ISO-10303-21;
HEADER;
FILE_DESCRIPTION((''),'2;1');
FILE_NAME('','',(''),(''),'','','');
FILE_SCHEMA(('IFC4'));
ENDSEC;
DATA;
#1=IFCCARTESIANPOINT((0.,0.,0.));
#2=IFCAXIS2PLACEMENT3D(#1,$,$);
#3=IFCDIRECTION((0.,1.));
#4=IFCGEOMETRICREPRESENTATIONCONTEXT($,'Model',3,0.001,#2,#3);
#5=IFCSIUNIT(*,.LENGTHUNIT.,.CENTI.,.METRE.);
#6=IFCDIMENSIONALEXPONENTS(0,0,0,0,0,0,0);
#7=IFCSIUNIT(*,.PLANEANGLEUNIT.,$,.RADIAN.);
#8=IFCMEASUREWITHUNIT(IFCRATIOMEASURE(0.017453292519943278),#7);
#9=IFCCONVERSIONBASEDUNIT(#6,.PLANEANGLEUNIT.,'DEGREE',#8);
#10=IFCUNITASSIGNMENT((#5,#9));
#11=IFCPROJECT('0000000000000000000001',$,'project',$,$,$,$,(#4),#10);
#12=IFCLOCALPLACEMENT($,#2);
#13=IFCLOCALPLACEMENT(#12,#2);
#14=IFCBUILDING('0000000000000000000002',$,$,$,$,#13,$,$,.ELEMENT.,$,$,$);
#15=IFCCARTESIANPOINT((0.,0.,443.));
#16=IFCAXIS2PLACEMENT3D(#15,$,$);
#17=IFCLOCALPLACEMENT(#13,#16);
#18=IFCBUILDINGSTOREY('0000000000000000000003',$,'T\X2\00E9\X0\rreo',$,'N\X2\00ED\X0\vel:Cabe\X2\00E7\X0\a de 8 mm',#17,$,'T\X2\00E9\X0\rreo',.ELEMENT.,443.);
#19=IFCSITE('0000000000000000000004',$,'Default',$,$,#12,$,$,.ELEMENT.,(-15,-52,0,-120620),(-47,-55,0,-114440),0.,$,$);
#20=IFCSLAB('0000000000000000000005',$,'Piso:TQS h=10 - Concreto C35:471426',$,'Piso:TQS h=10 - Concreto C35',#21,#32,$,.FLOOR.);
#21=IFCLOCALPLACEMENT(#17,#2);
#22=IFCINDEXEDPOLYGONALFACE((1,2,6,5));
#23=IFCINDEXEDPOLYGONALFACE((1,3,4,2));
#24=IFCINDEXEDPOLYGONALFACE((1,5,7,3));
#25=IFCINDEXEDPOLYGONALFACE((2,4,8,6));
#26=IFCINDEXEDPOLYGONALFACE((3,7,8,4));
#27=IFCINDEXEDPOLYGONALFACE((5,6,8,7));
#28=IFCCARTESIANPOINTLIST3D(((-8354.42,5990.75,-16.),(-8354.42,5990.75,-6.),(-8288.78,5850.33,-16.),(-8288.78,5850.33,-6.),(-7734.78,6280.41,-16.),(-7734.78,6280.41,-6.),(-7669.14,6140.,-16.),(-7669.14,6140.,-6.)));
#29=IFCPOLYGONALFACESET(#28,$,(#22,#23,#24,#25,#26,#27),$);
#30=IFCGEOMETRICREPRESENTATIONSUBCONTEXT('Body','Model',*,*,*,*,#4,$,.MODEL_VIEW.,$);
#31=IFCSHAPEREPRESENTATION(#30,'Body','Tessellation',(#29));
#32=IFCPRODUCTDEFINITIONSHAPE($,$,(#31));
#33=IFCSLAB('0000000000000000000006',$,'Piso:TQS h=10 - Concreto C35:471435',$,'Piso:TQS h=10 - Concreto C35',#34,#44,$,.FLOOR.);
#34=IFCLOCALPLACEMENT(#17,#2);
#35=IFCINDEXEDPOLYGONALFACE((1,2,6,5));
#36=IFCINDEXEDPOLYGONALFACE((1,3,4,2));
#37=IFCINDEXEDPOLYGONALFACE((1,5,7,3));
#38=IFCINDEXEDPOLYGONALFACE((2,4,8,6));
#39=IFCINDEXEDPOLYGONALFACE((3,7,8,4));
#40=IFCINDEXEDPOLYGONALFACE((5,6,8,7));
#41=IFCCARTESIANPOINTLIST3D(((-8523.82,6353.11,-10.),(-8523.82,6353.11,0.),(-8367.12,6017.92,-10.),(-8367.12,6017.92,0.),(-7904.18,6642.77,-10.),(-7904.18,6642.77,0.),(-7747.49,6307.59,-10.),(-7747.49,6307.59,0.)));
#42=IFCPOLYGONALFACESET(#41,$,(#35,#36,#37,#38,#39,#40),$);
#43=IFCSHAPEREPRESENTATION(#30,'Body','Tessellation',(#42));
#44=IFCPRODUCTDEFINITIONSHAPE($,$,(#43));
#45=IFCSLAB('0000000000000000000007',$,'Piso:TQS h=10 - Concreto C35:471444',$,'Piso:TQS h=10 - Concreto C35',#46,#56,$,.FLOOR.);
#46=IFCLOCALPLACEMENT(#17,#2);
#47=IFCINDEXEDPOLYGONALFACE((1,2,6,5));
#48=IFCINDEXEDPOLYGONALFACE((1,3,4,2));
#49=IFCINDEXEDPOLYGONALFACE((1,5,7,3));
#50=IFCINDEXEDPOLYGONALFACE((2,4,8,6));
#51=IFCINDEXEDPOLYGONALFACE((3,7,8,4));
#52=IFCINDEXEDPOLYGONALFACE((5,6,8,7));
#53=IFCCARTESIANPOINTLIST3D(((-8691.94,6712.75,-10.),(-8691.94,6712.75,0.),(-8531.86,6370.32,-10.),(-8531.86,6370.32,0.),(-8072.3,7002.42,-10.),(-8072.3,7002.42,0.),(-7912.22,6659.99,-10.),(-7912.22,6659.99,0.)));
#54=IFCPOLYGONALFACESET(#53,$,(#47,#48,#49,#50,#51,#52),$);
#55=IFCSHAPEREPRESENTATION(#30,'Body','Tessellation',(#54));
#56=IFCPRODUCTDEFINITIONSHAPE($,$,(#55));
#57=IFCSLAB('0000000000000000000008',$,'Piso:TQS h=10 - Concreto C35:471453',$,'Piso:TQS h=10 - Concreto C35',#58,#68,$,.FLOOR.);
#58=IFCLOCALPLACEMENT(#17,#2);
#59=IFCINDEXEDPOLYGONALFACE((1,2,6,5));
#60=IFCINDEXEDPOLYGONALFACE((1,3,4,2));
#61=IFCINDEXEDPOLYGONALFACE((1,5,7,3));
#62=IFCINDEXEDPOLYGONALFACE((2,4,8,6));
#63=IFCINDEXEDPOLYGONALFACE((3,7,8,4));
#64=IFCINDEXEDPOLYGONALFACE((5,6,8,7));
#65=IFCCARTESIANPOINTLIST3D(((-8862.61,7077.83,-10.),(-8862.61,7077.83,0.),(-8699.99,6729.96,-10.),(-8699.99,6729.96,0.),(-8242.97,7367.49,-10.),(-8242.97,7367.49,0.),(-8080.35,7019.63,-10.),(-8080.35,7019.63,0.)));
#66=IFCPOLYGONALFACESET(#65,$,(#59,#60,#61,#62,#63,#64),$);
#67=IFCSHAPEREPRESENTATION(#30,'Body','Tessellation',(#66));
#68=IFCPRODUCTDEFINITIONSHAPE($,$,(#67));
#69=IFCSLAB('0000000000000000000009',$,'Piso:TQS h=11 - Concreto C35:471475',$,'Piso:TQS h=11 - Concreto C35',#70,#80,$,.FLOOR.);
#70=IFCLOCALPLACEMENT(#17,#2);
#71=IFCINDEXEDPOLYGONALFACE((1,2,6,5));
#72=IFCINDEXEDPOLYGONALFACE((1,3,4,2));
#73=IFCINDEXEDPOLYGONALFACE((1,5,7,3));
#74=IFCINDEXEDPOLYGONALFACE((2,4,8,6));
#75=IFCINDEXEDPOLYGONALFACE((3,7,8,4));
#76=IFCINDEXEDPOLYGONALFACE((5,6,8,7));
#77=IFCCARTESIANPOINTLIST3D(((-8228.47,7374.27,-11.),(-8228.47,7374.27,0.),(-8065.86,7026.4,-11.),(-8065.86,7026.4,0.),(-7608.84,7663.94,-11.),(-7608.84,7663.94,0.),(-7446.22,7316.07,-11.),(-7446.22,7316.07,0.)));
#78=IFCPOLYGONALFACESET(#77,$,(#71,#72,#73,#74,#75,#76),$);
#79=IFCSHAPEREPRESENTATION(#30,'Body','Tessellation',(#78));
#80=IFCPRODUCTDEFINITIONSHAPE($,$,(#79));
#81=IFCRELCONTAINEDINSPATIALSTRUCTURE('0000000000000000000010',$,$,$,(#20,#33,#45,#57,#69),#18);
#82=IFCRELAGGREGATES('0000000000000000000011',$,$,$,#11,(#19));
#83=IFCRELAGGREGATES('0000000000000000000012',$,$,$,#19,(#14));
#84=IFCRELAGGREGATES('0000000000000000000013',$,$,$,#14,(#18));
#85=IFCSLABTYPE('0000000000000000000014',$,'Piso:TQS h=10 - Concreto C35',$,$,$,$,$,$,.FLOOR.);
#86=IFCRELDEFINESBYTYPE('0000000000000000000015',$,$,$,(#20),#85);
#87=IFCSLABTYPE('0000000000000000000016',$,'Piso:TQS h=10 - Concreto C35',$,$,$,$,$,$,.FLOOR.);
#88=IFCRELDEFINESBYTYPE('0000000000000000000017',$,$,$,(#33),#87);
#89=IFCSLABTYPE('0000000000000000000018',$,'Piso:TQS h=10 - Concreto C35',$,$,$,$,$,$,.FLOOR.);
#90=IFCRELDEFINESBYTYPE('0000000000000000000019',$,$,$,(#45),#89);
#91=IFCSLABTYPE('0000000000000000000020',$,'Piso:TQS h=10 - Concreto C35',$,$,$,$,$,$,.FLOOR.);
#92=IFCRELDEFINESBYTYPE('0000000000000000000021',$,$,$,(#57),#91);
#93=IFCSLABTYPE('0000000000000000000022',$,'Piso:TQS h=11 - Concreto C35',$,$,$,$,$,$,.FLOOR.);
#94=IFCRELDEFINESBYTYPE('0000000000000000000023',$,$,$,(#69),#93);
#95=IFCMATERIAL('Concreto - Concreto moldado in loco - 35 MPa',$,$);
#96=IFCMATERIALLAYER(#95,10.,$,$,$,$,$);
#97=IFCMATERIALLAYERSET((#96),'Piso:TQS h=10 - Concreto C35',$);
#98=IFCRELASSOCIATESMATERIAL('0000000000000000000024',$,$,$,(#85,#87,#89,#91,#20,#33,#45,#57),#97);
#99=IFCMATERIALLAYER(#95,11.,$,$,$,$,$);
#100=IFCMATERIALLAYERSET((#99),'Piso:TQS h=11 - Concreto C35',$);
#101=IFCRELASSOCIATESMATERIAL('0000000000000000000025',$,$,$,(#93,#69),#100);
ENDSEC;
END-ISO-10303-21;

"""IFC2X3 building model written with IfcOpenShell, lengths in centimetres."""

from ifc_helpers import new_model, entity, si_unit, converted_unit, direction, frame, frame_2d, origin, origin_2d_with_axis, place, context, subcontext, project, spatial, rectangle, extrude, material, layer, layer_set, layer_usage, type_object, element, save


model = new_model("IFC2X3")

# Units and contexts
model_context = context("Model", 3, precision=0.001, world=origin(), true_north=direction((0.0, 1.0)))
body_context = subcontext(model_context, "Body", "Model", "MODEL_VIEW")
ifc_project = project(units=[si_unit("LENGTHUNIT", "METRE", prefix="CENTI"), converted_unit("PLANEANGLEUNIT", "DEGREE", entity("IfcRatioMeasure", 0.017453292519943278), si_unit("PLANEANGLEUNIT", "RADIAN"), dimensions=[0, 0, 0, 0, 0, 0, 0])], contexts=[model_context])

# Site, building, storey
site_placement = place(None, origin())
site = spatial("IfcSite", under=ifc_project, at=site_placement, Name="Default", CompositionType="ELEMENT", RefLatitude=(-15, -52, 0, -120620), RefLongitude=(-47, -55, 0, -114440), RefElevation=0.0)
building_placement = place(site_placement, origin())
building = spatial("IfcBuilding", under=site, at=building_placement, CompositionType="ELEMENT")
storey_placement = place(building_placement, frame((0.0, 0.0, 443.0)))
storey = spatial("IfcBuildingStorey", under=building, at=storey_placement, Name="Térreo", ObjectType="Nível:Cabeça de 8 mm", LongName="Térreo", CompositionType="ELEMENT", Elevation=443.0)

# Slabs
ifc_material = material(Name="Concreto - Concreto moldado in loco - 35 MPa")
ifc_layer_1 = layer(ifc_material, 11.0)
ifc_layer_set_1 = layer_set([ifc_layer_1], Name="Piso:TQS h=11 - Concreto C35")
ifc_layer_2 = layer(ifc_material, 10.0)
ifc_layer_set_2 = layer_set([ifc_layer_2], Name="Piso:TQS h=10 - Concreto C35")
ifc_layer_usage_1 = layer_usage(ifc_layer_set_2, "AXIS3", "POSITIVE", 0.0)
slab_type_1 = type_object("IfcSlabType", Name="Piso:TQS h=10 - Concreto C35", PredefinedType="FLOOR", material=ifc_layer_set_2)
slab_1_placement = place(storey_placement, origin())
element("IfcSlab", 1, at=slab_1_placement, inside=storey, type_object=slab_type_1, material=ifc_layer_usage_1, Name="Piso:TQS h=10 - Concreto C35:471426", ObjectType="Piso:TQS h=10 - Concreto C35", PredefinedType="FLOOR", context=body_context, shape_type="SweptSolid", body=[
    extrude(rectangle(XDim=155.0, YDim=684.0, at=frame_2d((0.0, 0.0), x_axis=(1.0, 0.0))), frame((-8011.78, 6065.37, -6.0), z_axis=(0.0, 0.0, -1.0), x_axis=(0.423488, -0.905902, 0.0)), (0.0, 0.0, 1.0), 10.0),
])
ifc_layer_usage_2 = layer_usage(ifc_layer_set_2, "AXIS3", "POSITIVE", 0.0)
slab_type_2 = type_object("IfcSlabType", Name="Piso:TQS h=10 - Concreto C35", PredefinedType="FLOOR", material=ifc_layer_set_2)
slab_2_placement = place(storey_placement, origin())
element("IfcSlab", 2, at=slab_2_placement, inside=storey, type_object=slab_type_2, material=ifc_layer_usage_2, Name="Piso:TQS h=10 - Concreto C35:471435", ObjectType="Piso:TQS h=10 - Concreto C35", PredefinedType="FLOOR", context=body_context, shape_type="SweptSolid", body=[
    extrude(rectangle(XDim=684.0, YDim=370.0, at=frame_2d((0.0, 0.0), x_axis=(1.0, 0.0))), frame((-8135.65, 6330.35, 0.0), z_axis=(0.0, 0.0, -1.0), x_axis=(0.905902, 0.423488, 0.0)), (0.0, 0.0, 1.0), 10.0),
])
ifc_layer_usage_3 = layer_usage(ifc_layer_set_2, "AXIS3", "POSITIVE", 0.0)
slab_type_3 = type_object("IfcSlabType", Name="Piso:TQS h=10 - Concreto C35", PredefinedType="FLOOR", material=ifc_layer_set_2)
slab_3_placement = place(storey_placement, origin())
element("IfcSlab", 3, at=slab_3_placement, inside=storey, type_object=slab_type_3, material=ifc_layer_usage_3, Name="Piso:TQS h=10 - Concreto C35:471444", ObjectType="Piso:TQS h=10 - Concreto C35", PredefinedType="FLOOR", context=body_context, shape_type="SweptSolid", body=[
    extrude(rectangle(XDim=684.0, YDim=378.0, at=frame_2d((0.0, 0.0), x_axis=(1.0, 0.0))), frame((-8302.08, 6686.37, 0.0), z_axis=(0.0, 0.0, -1.0), x_axis=(0.905902, 0.423488, 0.0)), (0.0, 0.0, 1.0), 10.0),
])
ifc_layer_usage_4 = layer_usage(ifc_layer_set_2, "AXIS3", "POSITIVE", 0.0)
slab_type_4 = type_object("IfcSlabType", Name="Piso:TQS h=10 - Concreto C35", PredefinedType="FLOOR", material=ifc_layer_set_2)
slab_4_placement = place(storey_placement, origin())
element("IfcSlab", 4, at=slab_4_placement, inside=storey, type_object=slab_type_4, material=ifc_layer_usage_4, Name="Piso:TQS h=10 - Concreto C35:471453", ObjectType="Piso:TQS h=10 - Concreto C35", PredefinedType="FLOOR", context=body_context, shape_type="SweptSolid", body=[
    extrude(rectangle(XDim=684.0, YDim=384.0, at=origin_2d_with_axis()), frame((-8471.48, 7048.73, 0.0), z_axis=(0.0, 0.0, -1.0), x_axis=(0.905902, 0.423488, 0.0)), (0.0, 0.0, 1.0), 10.0),
])
ifc_layer_usage_5 = layer_usage(ifc_layer_set_1, "AXIS3", "POSITIVE", 0.0)
slab_type_5 = type_object("IfcSlabType", Name="Piso:TQS h=11 - Concreto C35", PredefinedType="FLOOR", material=ifc_layer_set_1)
slab_5_placement = place(storey_placement, origin())
element("IfcSlab", 5, at=slab_5_placement, inside=storey, type_object=slab_type_5, material=ifc_layer_usage_5, Name="Piso:TQS h=11 - Concreto C35:471475", ObjectType="Piso:TQS h=11 - Concreto C35", PredefinedType="FLOOR", context=body_context, shape_type="SweptSolid", body=[
    extrude(rectangle(XDim=684.0, YDim=384.0, at=frame_2d((0.0, 0.0), x_axis=(1.0, 0.0))), frame((-7837.35, 7345.17, 0.0), z_axis=(0.0, 0.0, -1.0), x_axis=(-0.905902, -0.423488, 0.0)), (0.0, 0.0, 1.0), 11.0),
])

save(model, "model.ifc")
